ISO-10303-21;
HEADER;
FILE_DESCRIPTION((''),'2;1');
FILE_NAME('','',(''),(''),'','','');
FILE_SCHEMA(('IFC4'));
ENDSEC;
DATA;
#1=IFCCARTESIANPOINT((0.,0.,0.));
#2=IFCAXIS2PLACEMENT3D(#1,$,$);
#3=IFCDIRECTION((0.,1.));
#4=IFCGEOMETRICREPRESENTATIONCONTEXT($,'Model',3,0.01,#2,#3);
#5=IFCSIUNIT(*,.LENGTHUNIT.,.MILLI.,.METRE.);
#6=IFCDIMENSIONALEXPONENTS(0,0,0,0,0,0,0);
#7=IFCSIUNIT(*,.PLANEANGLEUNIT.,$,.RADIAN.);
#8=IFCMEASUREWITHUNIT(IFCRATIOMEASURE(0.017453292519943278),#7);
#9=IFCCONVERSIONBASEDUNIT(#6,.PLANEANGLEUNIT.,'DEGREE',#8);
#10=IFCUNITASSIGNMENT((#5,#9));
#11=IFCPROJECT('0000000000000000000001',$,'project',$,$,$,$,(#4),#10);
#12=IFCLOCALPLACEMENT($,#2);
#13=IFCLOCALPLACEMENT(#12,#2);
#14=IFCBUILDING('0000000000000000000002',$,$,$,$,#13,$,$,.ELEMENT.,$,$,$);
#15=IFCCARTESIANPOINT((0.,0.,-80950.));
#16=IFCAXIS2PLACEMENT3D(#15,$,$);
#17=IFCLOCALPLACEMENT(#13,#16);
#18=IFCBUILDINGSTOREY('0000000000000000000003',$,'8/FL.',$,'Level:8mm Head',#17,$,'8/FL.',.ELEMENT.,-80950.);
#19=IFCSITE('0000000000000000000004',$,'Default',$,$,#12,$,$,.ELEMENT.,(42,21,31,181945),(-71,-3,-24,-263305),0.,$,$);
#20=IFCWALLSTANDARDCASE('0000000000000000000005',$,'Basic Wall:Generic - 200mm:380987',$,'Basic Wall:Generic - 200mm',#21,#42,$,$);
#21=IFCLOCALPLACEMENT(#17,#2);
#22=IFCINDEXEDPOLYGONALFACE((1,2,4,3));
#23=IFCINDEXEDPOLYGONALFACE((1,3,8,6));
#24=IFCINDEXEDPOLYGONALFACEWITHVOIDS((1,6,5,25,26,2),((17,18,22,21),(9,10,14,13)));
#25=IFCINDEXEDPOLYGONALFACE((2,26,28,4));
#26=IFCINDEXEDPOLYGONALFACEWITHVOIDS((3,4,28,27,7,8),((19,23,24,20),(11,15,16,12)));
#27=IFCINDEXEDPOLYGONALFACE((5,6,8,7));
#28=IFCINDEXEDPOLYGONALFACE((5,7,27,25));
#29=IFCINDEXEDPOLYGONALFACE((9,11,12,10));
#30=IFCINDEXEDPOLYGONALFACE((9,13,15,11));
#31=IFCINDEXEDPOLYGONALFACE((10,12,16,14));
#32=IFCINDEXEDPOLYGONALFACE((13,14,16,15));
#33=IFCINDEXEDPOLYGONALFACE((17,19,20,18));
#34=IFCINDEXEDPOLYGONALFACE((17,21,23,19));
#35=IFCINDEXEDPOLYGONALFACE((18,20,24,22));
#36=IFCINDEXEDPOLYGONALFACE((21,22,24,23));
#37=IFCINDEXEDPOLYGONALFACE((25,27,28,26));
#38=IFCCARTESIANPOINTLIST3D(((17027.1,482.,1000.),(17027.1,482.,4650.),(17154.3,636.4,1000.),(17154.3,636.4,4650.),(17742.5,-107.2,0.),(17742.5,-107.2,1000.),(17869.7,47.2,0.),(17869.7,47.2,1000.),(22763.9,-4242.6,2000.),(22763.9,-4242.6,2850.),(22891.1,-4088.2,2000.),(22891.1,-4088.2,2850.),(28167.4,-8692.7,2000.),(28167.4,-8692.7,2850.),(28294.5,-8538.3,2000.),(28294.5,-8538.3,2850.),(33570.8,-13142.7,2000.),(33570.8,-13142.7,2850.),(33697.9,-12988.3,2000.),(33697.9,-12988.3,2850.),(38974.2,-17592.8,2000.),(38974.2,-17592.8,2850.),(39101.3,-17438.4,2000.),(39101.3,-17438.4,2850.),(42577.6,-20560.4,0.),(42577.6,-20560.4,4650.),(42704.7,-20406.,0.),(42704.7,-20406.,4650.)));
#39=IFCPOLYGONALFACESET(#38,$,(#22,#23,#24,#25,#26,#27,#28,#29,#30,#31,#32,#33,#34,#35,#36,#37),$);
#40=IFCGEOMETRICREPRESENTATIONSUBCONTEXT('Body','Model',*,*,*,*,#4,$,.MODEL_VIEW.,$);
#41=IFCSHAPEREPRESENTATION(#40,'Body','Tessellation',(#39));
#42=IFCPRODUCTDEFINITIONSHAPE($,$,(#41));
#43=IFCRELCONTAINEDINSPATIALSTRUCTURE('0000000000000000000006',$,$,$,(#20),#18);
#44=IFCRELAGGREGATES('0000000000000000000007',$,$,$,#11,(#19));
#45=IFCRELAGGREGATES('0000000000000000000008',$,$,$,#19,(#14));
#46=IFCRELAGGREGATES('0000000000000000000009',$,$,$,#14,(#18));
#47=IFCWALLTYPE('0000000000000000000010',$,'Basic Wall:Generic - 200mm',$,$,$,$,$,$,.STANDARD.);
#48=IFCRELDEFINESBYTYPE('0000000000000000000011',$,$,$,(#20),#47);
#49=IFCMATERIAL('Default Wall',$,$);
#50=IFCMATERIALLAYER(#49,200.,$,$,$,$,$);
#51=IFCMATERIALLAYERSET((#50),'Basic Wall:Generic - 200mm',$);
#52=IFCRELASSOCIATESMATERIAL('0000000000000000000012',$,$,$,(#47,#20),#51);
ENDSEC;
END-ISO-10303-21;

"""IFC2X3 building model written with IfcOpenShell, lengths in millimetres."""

from ifc_helpers import new_model, entity, si_unit, converted_unit, direction, frame, frame_2d, origin, place, context, subcontext, project, spatial, rectangle, extrude, material, layer, layer_set, layer_usage, type_object, element, save


model = new_model("IFC2X3")

# Units and contexts
model_context = context("Model", 3, precision=0.01, world=origin(), true_north=direction((0.0, 1.0)))
body_context = subcontext(model_context, "Body", "Model", "MODEL_VIEW")
ifc_project = project(units=[si_unit("LENGTHUNIT", "METRE", prefix="MILLI"), converted_unit("PLANEANGLEUNIT", "DEGREE", entity("IfcRatioMeasure", 0.017453292519943278), si_unit("PLANEANGLEUNIT", "RADIAN"), dimensions=[0, 0, 0, 0, 0, 0, 0])], contexts=[model_context])

# Site, building, storey
site_placement = place(None, origin())
site = spatial("IfcSite", under=ifc_project, at=site_placement, Name="Default", CompositionType="ELEMENT", RefLatitude=(42, 21, 31, 181945), RefLongitude=(-71, -3, -24, -263305), RefElevation=0.0)
building_placement = place(site_placement, origin())
building = spatial("IfcBuilding", under=site, at=building_placement, CompositionType="ELEMENT")
storey_placement = place(building_placement, frame((0.0, 0.0, -80950.0)))
storey = spatial("IfcBuildingStorey", under=building, at=storey_placement, Name="8/FL.", ObjectType="Level:8mm Head", LongName="8/FL.", CompositionType="ELEMENT", Elevation=-80950.0)

# Wall, openings
ifc_material_1 = material(Name="Default Wall")
ifc_layer = layer(ifc_material_1, 200.0)
ifc_layer_set = layer_set([ifc_layer], Name="Basic Wall:Generic - 200mm")
ifc_layer_usage = layer_usage(ifc_layer_set, "AXIS2", "NEGATIVE", 100.0)
wall_type = type_object("IfcWallType", Name="Basic Wall:Generic - 200mm", PredefinedType="STANDARD", material=ifc_layer_set)
wall_1_placement = place(storey_placement, frame((42641.2, -20483.2, 0.0), z_axis=(0.0, 0.0, 1.0), x_axis=(-0.771917, 0.635723, 0.0)))
wall_1 = element("IfcWallStandardCase", 1, at=wall_1_placement, inside=storey, type_object=wall_type, material=ifc_layer_usage, Name="Basic Wall:Generic - 200mm:380987", ObjectType="Basic Wall:Generic - 200mm", context=body_context, shape_type="SweptSolid", body=[
    extrude(rectangle(XDim=33100.0, YDim=200.0, at=frame_2d((16550.0, 0.0), x_axis=(-1.0, 0.0))), origin(), (0.0, 0.0, 1.0), 4650.0),
])
opening_1_placement = place(wall_1_placement, origin())
element("IfcOpeningElement", 2, at=opening_1_placement, cuts=wall_1, ObjectType="Opening", context=body_context, shape_type="SweptSolid", body=[
    extrude(rectangle(XDim=850.0, YDim=7000.0, at=frame_2d((0.0, 0.0), x_axis=(1.0, 0.0))), frame((8168.1, -100.0, 2425.0), z_axis=(0.0, 1.0, 0.0), x_axis=(0.0, 0.0, -1.0)), (0.0, 0.0, 1.0), 200.0),
])
opening_2_placement = place(wall_1_placement, origin())
element("IfcOpeningElement", 3, at=opening_2_placement, cuts=wall_1, ObjectType="Opening", context=body_context, shape_type="SweptSolid", body=[
    extrude(rectangle(XDim=850.0, YDim=7000.0, at=frame_2d((0.0, 0.0), x_axis=(1.0, 0.0))), frame((22168.1, -100.0, 2425.0), z_axis=(0.0, 1.0, 0.0), x_axis=(0.0, 0.0, -1.0)), (0.0, 0.0, 1.0), 200.0),
])
opening_3_placement = place(wall_1_placement, frame((45937.1, 11296.6, 0.0), z_axis=(0.0, 0.0, 1.0), x_axis=(-0.771917, -0.635723, 0.0)))
element("IfcOpeningElement", 4, at=opening_3_placement, cuts=wall_1, ObjectType="Opening", context=body_context, shape_type="SweptSolid", body=[
    extrude(rectangle(XDim=1000.0, YDim=1010.1, at=frame_2d((0.0, 0.0), x_axis=(1.0, 0.0))), frame((17487.9, 378.1, 500.0), z_axis=(-0.635723, -0.771917, 0.0), x_axis=(0.0, 0.0, -1.0)), (0.0, 0.0, 1.0), 1012.7),
])

save(model, "model.ifc")
